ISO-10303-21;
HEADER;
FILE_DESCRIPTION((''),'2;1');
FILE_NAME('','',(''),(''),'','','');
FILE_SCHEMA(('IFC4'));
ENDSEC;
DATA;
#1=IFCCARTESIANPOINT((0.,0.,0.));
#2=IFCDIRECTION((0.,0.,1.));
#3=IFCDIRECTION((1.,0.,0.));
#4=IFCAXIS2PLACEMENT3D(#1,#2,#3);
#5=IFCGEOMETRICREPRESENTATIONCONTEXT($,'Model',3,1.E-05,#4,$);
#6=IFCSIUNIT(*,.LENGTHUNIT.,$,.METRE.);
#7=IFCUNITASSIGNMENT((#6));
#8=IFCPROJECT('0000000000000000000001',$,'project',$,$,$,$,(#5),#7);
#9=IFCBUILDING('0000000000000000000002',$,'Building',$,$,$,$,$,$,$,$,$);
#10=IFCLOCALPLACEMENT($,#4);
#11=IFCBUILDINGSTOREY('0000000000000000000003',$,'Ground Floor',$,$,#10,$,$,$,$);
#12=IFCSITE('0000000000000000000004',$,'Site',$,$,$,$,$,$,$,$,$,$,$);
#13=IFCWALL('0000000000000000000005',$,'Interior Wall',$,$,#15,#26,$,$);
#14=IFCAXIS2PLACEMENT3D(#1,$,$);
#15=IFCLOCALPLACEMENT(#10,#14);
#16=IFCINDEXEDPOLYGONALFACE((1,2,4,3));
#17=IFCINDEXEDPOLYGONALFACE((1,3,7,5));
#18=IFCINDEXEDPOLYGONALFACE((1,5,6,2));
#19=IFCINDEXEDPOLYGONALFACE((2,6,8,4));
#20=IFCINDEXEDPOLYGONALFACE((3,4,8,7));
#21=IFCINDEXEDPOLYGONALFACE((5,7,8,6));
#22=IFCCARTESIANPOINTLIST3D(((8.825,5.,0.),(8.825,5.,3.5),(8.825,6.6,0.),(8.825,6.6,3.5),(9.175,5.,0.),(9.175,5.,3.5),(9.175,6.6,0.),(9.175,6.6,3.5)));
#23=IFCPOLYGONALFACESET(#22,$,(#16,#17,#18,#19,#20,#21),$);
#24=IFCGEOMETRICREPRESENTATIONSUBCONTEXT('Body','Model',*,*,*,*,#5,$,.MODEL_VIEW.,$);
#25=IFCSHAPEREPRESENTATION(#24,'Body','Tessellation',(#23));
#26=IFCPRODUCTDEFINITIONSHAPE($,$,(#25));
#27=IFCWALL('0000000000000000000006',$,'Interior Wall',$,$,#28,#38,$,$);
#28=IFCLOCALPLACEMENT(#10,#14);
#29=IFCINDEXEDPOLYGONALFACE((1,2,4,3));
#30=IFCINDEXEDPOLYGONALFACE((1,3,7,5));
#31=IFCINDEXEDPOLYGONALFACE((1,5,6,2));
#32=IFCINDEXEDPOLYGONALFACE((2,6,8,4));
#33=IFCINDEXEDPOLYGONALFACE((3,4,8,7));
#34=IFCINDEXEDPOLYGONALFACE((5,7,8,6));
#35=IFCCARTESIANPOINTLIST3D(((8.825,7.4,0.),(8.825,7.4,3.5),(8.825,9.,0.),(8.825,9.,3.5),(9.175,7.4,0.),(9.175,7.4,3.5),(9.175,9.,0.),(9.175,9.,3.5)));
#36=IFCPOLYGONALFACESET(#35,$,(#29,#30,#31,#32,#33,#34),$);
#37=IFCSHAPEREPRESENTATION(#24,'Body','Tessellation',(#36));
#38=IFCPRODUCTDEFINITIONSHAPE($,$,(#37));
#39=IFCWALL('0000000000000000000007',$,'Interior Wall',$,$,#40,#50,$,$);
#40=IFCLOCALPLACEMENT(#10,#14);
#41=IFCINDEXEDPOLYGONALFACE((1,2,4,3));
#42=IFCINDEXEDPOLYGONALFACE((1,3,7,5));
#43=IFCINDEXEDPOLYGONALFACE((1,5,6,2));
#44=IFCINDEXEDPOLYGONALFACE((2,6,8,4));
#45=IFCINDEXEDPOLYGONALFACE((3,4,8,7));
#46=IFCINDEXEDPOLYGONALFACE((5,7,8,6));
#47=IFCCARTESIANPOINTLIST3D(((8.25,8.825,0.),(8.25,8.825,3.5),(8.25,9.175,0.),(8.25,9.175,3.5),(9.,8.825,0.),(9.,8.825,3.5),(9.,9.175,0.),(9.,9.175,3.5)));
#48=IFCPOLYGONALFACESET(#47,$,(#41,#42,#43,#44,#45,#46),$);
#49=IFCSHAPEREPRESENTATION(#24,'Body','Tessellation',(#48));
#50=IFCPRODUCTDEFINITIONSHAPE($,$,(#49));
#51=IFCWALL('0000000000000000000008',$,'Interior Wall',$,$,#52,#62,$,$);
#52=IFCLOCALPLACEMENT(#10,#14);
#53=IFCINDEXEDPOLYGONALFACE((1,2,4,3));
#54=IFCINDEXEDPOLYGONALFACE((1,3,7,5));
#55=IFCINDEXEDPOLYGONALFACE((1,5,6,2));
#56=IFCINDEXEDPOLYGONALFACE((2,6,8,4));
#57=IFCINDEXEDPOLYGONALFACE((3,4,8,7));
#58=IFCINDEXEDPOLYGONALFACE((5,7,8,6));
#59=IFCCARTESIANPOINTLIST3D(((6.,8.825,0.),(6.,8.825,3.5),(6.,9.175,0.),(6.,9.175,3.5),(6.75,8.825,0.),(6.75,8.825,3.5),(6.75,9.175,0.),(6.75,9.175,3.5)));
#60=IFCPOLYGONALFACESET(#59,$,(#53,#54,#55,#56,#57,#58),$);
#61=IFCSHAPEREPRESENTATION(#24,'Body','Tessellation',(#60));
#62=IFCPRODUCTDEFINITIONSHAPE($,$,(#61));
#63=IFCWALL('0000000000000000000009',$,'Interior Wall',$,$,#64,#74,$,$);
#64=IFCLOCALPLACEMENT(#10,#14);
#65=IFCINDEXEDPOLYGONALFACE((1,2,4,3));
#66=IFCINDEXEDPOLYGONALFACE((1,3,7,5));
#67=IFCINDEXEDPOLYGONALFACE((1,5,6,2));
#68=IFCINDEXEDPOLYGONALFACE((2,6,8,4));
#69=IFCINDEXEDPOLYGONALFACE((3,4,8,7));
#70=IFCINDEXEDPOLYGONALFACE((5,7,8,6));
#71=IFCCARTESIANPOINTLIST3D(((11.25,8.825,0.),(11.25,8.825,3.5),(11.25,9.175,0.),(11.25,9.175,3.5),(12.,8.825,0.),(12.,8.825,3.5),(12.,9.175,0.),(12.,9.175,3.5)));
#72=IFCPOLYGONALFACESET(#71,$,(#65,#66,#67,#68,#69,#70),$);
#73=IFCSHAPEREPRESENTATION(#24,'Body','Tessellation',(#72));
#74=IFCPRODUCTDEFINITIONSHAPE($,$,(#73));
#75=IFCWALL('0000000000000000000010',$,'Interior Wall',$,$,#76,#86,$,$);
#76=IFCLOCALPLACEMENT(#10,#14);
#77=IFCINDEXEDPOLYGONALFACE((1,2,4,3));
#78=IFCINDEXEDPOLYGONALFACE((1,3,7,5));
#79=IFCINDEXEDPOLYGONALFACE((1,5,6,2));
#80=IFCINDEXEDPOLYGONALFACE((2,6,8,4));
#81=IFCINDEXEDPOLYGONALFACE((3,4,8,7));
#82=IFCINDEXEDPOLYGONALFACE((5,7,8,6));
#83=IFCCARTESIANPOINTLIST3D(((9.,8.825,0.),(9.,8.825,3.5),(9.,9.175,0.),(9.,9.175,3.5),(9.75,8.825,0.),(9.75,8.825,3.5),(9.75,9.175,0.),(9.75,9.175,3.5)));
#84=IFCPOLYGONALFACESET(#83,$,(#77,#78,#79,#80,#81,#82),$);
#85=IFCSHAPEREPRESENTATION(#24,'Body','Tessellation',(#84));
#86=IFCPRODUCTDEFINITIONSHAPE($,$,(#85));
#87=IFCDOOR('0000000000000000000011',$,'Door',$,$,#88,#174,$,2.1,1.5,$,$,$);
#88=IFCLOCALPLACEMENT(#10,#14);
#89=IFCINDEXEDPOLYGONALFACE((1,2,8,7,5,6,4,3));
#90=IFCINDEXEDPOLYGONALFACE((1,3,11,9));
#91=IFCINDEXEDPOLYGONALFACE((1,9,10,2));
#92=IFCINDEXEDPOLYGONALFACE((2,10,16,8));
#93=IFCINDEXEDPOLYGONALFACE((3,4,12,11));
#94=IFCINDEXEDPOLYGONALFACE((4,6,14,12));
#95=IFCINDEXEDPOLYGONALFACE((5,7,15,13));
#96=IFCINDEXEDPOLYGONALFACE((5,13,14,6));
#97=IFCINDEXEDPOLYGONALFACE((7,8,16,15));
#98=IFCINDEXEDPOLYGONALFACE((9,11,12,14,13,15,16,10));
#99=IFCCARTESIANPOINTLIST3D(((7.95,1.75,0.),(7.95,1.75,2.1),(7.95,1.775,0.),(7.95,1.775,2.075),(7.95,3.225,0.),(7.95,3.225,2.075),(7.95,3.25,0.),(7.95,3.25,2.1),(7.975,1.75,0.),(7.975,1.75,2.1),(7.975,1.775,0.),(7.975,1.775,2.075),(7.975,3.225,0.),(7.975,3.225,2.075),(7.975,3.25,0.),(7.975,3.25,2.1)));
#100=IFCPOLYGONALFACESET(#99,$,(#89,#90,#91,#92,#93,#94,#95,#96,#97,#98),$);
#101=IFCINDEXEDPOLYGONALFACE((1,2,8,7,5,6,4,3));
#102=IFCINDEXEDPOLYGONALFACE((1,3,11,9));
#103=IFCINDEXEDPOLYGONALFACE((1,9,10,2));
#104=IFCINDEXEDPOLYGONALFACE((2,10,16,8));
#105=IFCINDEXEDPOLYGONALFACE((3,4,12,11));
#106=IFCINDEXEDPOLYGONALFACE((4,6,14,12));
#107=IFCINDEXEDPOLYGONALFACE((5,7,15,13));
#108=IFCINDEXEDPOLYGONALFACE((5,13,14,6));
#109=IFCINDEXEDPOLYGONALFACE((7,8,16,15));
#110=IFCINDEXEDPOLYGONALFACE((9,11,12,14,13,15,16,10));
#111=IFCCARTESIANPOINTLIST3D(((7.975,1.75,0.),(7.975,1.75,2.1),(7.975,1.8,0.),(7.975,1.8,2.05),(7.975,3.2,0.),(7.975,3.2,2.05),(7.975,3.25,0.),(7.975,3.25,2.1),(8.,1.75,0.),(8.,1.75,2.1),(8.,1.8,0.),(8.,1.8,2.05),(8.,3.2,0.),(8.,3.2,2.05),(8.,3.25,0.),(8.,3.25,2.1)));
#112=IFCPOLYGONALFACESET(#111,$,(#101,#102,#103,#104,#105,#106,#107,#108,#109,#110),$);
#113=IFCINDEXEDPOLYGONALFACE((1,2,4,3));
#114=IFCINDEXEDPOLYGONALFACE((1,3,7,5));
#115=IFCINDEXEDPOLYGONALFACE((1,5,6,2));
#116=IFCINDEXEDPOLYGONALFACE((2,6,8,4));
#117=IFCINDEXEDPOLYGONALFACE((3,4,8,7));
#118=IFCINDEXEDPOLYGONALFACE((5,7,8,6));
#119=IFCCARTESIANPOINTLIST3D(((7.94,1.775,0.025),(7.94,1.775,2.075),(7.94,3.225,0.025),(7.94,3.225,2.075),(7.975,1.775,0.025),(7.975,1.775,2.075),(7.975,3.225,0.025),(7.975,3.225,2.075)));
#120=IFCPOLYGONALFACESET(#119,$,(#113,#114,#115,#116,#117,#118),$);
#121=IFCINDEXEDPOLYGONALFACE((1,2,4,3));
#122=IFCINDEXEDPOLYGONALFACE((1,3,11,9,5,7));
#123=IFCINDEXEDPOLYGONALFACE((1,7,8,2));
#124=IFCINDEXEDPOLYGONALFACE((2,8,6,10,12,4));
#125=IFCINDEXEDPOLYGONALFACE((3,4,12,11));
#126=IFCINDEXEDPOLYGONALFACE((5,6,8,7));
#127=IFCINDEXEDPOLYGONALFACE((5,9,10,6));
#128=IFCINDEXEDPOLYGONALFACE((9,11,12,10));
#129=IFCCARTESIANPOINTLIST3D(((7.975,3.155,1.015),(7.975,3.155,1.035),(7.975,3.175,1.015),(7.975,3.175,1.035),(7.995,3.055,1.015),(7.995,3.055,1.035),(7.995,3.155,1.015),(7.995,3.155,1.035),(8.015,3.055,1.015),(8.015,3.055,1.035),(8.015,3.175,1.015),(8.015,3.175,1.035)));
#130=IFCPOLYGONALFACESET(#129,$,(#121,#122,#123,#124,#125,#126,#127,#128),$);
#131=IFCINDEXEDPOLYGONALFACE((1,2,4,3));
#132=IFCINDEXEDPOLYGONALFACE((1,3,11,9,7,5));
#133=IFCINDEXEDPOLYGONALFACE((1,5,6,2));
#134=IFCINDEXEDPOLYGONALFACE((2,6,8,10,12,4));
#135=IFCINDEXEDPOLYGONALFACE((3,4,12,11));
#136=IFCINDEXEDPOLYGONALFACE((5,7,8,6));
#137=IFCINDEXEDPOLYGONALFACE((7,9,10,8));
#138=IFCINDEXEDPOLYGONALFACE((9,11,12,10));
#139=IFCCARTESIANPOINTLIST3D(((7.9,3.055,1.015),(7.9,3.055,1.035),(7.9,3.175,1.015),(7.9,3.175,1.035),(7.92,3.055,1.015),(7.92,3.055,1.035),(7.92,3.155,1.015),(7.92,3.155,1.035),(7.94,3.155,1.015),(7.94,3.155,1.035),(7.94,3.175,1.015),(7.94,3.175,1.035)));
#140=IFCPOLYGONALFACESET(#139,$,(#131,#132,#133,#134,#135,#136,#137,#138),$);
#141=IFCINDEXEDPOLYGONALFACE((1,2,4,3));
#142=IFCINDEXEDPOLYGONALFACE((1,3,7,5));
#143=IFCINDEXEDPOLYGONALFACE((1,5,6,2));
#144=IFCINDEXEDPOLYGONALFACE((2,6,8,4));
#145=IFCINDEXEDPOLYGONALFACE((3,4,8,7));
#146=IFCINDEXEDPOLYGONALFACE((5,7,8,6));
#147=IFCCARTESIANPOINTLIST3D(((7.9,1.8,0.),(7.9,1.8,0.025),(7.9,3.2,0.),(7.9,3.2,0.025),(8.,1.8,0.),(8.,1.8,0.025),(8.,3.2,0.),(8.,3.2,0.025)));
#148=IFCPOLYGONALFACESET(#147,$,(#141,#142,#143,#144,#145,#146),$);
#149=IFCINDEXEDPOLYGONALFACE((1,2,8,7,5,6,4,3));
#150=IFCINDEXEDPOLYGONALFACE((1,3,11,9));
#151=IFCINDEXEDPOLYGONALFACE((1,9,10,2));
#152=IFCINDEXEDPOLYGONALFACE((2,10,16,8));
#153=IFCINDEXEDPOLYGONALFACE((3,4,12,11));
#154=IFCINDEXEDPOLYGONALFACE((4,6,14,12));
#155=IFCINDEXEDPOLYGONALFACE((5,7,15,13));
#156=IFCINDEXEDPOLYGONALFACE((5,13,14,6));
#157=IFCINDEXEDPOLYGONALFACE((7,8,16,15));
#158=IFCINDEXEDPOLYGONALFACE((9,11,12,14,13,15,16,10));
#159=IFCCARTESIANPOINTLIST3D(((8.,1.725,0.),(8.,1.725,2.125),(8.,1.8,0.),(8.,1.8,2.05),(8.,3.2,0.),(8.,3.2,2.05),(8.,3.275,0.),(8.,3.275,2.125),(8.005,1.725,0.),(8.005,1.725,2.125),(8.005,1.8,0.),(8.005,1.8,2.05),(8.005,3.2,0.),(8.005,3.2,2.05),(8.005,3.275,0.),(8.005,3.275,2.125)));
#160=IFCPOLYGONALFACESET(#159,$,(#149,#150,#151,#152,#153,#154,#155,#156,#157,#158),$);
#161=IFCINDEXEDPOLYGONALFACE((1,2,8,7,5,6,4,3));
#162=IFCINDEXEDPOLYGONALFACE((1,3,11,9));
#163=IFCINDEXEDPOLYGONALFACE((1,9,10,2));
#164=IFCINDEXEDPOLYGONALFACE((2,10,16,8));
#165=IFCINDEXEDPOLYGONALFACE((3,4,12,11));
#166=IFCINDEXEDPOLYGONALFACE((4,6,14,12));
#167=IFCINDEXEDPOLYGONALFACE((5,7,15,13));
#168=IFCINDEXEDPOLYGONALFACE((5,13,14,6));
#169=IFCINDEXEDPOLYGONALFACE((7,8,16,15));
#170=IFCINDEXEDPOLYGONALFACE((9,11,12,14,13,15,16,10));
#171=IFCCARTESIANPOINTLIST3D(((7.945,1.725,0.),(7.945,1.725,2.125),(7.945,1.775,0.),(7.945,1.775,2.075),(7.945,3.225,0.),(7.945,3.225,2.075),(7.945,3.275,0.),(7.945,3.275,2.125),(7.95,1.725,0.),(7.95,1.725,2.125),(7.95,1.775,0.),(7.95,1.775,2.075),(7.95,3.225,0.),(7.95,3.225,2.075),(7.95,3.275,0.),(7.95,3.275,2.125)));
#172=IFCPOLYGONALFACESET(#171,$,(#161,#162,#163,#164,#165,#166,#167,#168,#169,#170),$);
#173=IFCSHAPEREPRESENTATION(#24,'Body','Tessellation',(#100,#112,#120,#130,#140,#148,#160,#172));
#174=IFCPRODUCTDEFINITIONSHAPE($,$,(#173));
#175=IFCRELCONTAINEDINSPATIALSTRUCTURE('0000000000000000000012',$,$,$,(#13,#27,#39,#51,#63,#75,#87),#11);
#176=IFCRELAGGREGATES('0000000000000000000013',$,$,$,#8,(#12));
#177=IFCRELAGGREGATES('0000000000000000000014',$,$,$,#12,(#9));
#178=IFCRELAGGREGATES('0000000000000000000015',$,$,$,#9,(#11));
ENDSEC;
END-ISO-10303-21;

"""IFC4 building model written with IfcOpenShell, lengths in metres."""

from ifc_helpers import new_model, si_unit, frame, origin_with_axes, place, context, subcontext, project, spatial, line, indexed_curve, outline, extrude, element, save


model = new_model("IFC4")

# Units and contexts
model_context = context("Model", 3, precision=1e-05, world=origin_with_axes())
body_context = subcontext(model_context, "Body", "Model", "MODEL_VIEW")
ifc_project = project(units=[si_unit("LENGTHUNIT", "METRE")], contexts=[model_context])

# Site, building, storey
site = spatial("IfcSite", under=ifc_project, Name="Site")
building = spatial("IfcBuilding", under=site, Name="Building")
storey_placement = place(None, origin_with_axes())
storey = spatial("IfcBuildingStorey", under=building, at=storey_placement, Name="Ground Floor")

# Walls
for number, where, z_axis, x_axis, name in (
    (1, (9.0, 5.0, 0.0), (0.0, 0.0, 1.0), (0.0, 1.0, 0.0), "Interior Wall"),
    (2, (9.0, 7.4, 0.0), (0.0, 0.0, 1.0), (0.0, 1.0, 0.0), "Interior Wall"),
):
    element("IfcWall", number, at=place(storey_placement, frame(where, z_axis=z_axis, x_axis=x_axis)), inside=storey, Name=name, context=body_context, shape_type="SweptSolid", body=[
        extrude(outline(indexed_curve([(0.0, 0.0), (0.0, 0.35), (1.6, 0.35), (1.6, 0.0), (0.0, 0.0)], self_intersect=False)), frame((0.0, -0.175, 0.0), z_axis=(0.0, 0.0, 1.0), x_axis=(1.0, 0.0, 0.0)), (0.0, 0.0, 1.0), 3.5),
    ])
for number, where, z_axis, x_axis, name in (
    (3, (9.0, 9.0, 0.0), (0.0, 0.0, 1.0), (-1.0, 0.0, 0.0), "Interior Wall"),
    (4, (6.75, 9.0, 0.0), (0.0, 0.0, 1.0), (-1.0, 0.0, 0.0), "Interior Wall"),
    (5, (12.0, 9.0, 0.0), (0.0, 0.0, 1.0), (-1.0, 0.0, 0.0), "Interior Wall"),
    (6, (9.75, 9.0, 0.0), (0.0, 0.0, 1.0), (-1.0, 0.0, 0.0), "Interior Wall"),
):
    element("IfcWall", number, at=place(storey_placement, frame(where, z_axis=z_axis, x_axis=x_axis)), inside=storey, Name=name, context=body_context, shape_type="SweptSolid", body=[
        extrude(outline(indexed_curve([(0.0, 0.0), (0.0, 0.35), (0.75, 0.35), (0.75, 0.0), (0.0, 0.0)], self_intersect=False)), frame((0.0, -0.175, 0.0), z_axis=(0.0, 0.0, 1.0), x_axis=(1.0, 0.0, 0.0)), (0.0, 0.0, 1.0), 3.5),
    ])

# Door
door_1_placement = place(storey_placement, frame((8.0, 1.75, 0.0), z_axis=(0.0, 0.0, 1.0), x_axis=(0.0, 1.0, 0.0)))
element("IfcDoor", 7, at=door_1_placement, inside=storey, Name="Door", OverallHeight=2.1, OverallWidth=1.5, context=body_context, shape_type="SweptSolid", body=[
    extrude(outline(indexed_curve([(0.0, 0.0), (0.0, 2.1), (1.5, 2.1), (1.5, 0.0), (1.475, 0.0), (1.475, 2.075), (0.025, 2.075), (0.025, 0.0)], segments=[line(1, 2, 3, 4, 5, 6, 7, 8, 1)])), frame((0.0, 0.025, 0.0), z_axis=(0.0, -1.0, 0.0), x_axis=(1.0, 0.0, 0.0)), (0.0, 0.0, -1.0), 0.025),
    extrude(outline(indexed_curve([(0.0, 0.0), (0.0, 2.1), (1.5, 2.1), (1.5, 0.0), (1.45, 0.0), (1.45, 2.05), (0.05, 2.05), (0.05, 0.0)], segments=[line(1, 2, 3, 4, 5, 6, 7, 8, 1)])), frame((0.0, 0.0, 0.0), z_axis=(0.0, -1.0, 0.0), x_axis=(1.0, 0.0, 0.0)), (0.0, 0.0, -1.0), 0.025),
    extrude(outline(indexed_curve([(0.0, 0.0), (1.45, 0.0), (1.45, 0.035), (0.0, 0.035)], segments=[line(1, 2, 3, 4, 1)])), frame((0.025, 0.025, 0.025), z_axis=(0.0, 0.0, 1.0), x_axis=(1.0, 0.0, 0.0)), (0.0, 0.0, 1.0), 2.05),
    extrude(outline(indexed_curve([(0.0, 0.0), (0.0, -0.04), (-0.12, -0.04), (-0.12, -0.02), (-0.02, -0.02), (-0.02, 0.0)], segments=[line(1, 2, 3, 4, 5, 6, 1)])), frame((1.425, 0.025, 1.015), z_axis=(0.0, 0.0, 1.0), x_axis=(1.0, 0.0, 0.0)), (0.0, 0.0, 1.0), 0.02),
    extrude(outline(indexed_curve([(0.0, 0.0), (0.0, 0.04), (-0.12, 0.04), (-0.12, 0.02), (-0.02, 0.02), (-0.02, 0.0)], segments=[line(1, 2, 3, 4, 5, 6, 1)])), frame((1.425, 0.06, 1.015), z_axis=(0.0, 0.0, 1.0), x_axis=(1.0, 0.0, 0.0)), (0.0, 0.0, 1.0), 0.02),
    extrude(outline(indexed_curve([(0.0, 0.0), (1.4, 0.0), (1.4, 0.1), (0.0, 0.1)], segments=[line(1, 2, 3, 4, 1)])), frame((0.05, 0.0, 0.0), z_axis=(0.0, 0.0, 1.0), x_axis=(1.0, 0.0, 0.0)), (0.0, 0.0, 1.0), 0.025),
    extrude(outline(indexed_curve([(0.0, 0.0), (0.0, 2.125), (1.55, 2.125), (1.55, 0.0), (1.475, 0.0), (1.475, 2.05), (0.075, 2.05), (0.075, 0.0)], segments=[line(1, 2, 3, 4, 5, 6, 7, 8, 1)])), frame((-0.025, -0.005, 0.0), z_axis=(0.0, -1.0, 0.0), x_axis=(1.0, 0.0, 0.0)), (0.0, 0.0, -1.0), 0.005),
    extrude(outline(indexed_curve([(0.0, 0.0), (0.0, 2.125), (1.55, 2.125), (1.55, 0.0), (1.5, 0.0), (1.5, 2.075), (0.05, 2.075), (0.05, 0.0)], segments=[line(1, 2, 3, 4, 5, 6, 7, 8, 1)])), frame((-0.025, 0.05, 0.0), z_axis=(0.0, -1.0, 0.0), x_axis=(1.0, 0.0, 0.0)), (0.0, 0.0, -1.0), 0.005),
])

save(model, "model.ifc")
